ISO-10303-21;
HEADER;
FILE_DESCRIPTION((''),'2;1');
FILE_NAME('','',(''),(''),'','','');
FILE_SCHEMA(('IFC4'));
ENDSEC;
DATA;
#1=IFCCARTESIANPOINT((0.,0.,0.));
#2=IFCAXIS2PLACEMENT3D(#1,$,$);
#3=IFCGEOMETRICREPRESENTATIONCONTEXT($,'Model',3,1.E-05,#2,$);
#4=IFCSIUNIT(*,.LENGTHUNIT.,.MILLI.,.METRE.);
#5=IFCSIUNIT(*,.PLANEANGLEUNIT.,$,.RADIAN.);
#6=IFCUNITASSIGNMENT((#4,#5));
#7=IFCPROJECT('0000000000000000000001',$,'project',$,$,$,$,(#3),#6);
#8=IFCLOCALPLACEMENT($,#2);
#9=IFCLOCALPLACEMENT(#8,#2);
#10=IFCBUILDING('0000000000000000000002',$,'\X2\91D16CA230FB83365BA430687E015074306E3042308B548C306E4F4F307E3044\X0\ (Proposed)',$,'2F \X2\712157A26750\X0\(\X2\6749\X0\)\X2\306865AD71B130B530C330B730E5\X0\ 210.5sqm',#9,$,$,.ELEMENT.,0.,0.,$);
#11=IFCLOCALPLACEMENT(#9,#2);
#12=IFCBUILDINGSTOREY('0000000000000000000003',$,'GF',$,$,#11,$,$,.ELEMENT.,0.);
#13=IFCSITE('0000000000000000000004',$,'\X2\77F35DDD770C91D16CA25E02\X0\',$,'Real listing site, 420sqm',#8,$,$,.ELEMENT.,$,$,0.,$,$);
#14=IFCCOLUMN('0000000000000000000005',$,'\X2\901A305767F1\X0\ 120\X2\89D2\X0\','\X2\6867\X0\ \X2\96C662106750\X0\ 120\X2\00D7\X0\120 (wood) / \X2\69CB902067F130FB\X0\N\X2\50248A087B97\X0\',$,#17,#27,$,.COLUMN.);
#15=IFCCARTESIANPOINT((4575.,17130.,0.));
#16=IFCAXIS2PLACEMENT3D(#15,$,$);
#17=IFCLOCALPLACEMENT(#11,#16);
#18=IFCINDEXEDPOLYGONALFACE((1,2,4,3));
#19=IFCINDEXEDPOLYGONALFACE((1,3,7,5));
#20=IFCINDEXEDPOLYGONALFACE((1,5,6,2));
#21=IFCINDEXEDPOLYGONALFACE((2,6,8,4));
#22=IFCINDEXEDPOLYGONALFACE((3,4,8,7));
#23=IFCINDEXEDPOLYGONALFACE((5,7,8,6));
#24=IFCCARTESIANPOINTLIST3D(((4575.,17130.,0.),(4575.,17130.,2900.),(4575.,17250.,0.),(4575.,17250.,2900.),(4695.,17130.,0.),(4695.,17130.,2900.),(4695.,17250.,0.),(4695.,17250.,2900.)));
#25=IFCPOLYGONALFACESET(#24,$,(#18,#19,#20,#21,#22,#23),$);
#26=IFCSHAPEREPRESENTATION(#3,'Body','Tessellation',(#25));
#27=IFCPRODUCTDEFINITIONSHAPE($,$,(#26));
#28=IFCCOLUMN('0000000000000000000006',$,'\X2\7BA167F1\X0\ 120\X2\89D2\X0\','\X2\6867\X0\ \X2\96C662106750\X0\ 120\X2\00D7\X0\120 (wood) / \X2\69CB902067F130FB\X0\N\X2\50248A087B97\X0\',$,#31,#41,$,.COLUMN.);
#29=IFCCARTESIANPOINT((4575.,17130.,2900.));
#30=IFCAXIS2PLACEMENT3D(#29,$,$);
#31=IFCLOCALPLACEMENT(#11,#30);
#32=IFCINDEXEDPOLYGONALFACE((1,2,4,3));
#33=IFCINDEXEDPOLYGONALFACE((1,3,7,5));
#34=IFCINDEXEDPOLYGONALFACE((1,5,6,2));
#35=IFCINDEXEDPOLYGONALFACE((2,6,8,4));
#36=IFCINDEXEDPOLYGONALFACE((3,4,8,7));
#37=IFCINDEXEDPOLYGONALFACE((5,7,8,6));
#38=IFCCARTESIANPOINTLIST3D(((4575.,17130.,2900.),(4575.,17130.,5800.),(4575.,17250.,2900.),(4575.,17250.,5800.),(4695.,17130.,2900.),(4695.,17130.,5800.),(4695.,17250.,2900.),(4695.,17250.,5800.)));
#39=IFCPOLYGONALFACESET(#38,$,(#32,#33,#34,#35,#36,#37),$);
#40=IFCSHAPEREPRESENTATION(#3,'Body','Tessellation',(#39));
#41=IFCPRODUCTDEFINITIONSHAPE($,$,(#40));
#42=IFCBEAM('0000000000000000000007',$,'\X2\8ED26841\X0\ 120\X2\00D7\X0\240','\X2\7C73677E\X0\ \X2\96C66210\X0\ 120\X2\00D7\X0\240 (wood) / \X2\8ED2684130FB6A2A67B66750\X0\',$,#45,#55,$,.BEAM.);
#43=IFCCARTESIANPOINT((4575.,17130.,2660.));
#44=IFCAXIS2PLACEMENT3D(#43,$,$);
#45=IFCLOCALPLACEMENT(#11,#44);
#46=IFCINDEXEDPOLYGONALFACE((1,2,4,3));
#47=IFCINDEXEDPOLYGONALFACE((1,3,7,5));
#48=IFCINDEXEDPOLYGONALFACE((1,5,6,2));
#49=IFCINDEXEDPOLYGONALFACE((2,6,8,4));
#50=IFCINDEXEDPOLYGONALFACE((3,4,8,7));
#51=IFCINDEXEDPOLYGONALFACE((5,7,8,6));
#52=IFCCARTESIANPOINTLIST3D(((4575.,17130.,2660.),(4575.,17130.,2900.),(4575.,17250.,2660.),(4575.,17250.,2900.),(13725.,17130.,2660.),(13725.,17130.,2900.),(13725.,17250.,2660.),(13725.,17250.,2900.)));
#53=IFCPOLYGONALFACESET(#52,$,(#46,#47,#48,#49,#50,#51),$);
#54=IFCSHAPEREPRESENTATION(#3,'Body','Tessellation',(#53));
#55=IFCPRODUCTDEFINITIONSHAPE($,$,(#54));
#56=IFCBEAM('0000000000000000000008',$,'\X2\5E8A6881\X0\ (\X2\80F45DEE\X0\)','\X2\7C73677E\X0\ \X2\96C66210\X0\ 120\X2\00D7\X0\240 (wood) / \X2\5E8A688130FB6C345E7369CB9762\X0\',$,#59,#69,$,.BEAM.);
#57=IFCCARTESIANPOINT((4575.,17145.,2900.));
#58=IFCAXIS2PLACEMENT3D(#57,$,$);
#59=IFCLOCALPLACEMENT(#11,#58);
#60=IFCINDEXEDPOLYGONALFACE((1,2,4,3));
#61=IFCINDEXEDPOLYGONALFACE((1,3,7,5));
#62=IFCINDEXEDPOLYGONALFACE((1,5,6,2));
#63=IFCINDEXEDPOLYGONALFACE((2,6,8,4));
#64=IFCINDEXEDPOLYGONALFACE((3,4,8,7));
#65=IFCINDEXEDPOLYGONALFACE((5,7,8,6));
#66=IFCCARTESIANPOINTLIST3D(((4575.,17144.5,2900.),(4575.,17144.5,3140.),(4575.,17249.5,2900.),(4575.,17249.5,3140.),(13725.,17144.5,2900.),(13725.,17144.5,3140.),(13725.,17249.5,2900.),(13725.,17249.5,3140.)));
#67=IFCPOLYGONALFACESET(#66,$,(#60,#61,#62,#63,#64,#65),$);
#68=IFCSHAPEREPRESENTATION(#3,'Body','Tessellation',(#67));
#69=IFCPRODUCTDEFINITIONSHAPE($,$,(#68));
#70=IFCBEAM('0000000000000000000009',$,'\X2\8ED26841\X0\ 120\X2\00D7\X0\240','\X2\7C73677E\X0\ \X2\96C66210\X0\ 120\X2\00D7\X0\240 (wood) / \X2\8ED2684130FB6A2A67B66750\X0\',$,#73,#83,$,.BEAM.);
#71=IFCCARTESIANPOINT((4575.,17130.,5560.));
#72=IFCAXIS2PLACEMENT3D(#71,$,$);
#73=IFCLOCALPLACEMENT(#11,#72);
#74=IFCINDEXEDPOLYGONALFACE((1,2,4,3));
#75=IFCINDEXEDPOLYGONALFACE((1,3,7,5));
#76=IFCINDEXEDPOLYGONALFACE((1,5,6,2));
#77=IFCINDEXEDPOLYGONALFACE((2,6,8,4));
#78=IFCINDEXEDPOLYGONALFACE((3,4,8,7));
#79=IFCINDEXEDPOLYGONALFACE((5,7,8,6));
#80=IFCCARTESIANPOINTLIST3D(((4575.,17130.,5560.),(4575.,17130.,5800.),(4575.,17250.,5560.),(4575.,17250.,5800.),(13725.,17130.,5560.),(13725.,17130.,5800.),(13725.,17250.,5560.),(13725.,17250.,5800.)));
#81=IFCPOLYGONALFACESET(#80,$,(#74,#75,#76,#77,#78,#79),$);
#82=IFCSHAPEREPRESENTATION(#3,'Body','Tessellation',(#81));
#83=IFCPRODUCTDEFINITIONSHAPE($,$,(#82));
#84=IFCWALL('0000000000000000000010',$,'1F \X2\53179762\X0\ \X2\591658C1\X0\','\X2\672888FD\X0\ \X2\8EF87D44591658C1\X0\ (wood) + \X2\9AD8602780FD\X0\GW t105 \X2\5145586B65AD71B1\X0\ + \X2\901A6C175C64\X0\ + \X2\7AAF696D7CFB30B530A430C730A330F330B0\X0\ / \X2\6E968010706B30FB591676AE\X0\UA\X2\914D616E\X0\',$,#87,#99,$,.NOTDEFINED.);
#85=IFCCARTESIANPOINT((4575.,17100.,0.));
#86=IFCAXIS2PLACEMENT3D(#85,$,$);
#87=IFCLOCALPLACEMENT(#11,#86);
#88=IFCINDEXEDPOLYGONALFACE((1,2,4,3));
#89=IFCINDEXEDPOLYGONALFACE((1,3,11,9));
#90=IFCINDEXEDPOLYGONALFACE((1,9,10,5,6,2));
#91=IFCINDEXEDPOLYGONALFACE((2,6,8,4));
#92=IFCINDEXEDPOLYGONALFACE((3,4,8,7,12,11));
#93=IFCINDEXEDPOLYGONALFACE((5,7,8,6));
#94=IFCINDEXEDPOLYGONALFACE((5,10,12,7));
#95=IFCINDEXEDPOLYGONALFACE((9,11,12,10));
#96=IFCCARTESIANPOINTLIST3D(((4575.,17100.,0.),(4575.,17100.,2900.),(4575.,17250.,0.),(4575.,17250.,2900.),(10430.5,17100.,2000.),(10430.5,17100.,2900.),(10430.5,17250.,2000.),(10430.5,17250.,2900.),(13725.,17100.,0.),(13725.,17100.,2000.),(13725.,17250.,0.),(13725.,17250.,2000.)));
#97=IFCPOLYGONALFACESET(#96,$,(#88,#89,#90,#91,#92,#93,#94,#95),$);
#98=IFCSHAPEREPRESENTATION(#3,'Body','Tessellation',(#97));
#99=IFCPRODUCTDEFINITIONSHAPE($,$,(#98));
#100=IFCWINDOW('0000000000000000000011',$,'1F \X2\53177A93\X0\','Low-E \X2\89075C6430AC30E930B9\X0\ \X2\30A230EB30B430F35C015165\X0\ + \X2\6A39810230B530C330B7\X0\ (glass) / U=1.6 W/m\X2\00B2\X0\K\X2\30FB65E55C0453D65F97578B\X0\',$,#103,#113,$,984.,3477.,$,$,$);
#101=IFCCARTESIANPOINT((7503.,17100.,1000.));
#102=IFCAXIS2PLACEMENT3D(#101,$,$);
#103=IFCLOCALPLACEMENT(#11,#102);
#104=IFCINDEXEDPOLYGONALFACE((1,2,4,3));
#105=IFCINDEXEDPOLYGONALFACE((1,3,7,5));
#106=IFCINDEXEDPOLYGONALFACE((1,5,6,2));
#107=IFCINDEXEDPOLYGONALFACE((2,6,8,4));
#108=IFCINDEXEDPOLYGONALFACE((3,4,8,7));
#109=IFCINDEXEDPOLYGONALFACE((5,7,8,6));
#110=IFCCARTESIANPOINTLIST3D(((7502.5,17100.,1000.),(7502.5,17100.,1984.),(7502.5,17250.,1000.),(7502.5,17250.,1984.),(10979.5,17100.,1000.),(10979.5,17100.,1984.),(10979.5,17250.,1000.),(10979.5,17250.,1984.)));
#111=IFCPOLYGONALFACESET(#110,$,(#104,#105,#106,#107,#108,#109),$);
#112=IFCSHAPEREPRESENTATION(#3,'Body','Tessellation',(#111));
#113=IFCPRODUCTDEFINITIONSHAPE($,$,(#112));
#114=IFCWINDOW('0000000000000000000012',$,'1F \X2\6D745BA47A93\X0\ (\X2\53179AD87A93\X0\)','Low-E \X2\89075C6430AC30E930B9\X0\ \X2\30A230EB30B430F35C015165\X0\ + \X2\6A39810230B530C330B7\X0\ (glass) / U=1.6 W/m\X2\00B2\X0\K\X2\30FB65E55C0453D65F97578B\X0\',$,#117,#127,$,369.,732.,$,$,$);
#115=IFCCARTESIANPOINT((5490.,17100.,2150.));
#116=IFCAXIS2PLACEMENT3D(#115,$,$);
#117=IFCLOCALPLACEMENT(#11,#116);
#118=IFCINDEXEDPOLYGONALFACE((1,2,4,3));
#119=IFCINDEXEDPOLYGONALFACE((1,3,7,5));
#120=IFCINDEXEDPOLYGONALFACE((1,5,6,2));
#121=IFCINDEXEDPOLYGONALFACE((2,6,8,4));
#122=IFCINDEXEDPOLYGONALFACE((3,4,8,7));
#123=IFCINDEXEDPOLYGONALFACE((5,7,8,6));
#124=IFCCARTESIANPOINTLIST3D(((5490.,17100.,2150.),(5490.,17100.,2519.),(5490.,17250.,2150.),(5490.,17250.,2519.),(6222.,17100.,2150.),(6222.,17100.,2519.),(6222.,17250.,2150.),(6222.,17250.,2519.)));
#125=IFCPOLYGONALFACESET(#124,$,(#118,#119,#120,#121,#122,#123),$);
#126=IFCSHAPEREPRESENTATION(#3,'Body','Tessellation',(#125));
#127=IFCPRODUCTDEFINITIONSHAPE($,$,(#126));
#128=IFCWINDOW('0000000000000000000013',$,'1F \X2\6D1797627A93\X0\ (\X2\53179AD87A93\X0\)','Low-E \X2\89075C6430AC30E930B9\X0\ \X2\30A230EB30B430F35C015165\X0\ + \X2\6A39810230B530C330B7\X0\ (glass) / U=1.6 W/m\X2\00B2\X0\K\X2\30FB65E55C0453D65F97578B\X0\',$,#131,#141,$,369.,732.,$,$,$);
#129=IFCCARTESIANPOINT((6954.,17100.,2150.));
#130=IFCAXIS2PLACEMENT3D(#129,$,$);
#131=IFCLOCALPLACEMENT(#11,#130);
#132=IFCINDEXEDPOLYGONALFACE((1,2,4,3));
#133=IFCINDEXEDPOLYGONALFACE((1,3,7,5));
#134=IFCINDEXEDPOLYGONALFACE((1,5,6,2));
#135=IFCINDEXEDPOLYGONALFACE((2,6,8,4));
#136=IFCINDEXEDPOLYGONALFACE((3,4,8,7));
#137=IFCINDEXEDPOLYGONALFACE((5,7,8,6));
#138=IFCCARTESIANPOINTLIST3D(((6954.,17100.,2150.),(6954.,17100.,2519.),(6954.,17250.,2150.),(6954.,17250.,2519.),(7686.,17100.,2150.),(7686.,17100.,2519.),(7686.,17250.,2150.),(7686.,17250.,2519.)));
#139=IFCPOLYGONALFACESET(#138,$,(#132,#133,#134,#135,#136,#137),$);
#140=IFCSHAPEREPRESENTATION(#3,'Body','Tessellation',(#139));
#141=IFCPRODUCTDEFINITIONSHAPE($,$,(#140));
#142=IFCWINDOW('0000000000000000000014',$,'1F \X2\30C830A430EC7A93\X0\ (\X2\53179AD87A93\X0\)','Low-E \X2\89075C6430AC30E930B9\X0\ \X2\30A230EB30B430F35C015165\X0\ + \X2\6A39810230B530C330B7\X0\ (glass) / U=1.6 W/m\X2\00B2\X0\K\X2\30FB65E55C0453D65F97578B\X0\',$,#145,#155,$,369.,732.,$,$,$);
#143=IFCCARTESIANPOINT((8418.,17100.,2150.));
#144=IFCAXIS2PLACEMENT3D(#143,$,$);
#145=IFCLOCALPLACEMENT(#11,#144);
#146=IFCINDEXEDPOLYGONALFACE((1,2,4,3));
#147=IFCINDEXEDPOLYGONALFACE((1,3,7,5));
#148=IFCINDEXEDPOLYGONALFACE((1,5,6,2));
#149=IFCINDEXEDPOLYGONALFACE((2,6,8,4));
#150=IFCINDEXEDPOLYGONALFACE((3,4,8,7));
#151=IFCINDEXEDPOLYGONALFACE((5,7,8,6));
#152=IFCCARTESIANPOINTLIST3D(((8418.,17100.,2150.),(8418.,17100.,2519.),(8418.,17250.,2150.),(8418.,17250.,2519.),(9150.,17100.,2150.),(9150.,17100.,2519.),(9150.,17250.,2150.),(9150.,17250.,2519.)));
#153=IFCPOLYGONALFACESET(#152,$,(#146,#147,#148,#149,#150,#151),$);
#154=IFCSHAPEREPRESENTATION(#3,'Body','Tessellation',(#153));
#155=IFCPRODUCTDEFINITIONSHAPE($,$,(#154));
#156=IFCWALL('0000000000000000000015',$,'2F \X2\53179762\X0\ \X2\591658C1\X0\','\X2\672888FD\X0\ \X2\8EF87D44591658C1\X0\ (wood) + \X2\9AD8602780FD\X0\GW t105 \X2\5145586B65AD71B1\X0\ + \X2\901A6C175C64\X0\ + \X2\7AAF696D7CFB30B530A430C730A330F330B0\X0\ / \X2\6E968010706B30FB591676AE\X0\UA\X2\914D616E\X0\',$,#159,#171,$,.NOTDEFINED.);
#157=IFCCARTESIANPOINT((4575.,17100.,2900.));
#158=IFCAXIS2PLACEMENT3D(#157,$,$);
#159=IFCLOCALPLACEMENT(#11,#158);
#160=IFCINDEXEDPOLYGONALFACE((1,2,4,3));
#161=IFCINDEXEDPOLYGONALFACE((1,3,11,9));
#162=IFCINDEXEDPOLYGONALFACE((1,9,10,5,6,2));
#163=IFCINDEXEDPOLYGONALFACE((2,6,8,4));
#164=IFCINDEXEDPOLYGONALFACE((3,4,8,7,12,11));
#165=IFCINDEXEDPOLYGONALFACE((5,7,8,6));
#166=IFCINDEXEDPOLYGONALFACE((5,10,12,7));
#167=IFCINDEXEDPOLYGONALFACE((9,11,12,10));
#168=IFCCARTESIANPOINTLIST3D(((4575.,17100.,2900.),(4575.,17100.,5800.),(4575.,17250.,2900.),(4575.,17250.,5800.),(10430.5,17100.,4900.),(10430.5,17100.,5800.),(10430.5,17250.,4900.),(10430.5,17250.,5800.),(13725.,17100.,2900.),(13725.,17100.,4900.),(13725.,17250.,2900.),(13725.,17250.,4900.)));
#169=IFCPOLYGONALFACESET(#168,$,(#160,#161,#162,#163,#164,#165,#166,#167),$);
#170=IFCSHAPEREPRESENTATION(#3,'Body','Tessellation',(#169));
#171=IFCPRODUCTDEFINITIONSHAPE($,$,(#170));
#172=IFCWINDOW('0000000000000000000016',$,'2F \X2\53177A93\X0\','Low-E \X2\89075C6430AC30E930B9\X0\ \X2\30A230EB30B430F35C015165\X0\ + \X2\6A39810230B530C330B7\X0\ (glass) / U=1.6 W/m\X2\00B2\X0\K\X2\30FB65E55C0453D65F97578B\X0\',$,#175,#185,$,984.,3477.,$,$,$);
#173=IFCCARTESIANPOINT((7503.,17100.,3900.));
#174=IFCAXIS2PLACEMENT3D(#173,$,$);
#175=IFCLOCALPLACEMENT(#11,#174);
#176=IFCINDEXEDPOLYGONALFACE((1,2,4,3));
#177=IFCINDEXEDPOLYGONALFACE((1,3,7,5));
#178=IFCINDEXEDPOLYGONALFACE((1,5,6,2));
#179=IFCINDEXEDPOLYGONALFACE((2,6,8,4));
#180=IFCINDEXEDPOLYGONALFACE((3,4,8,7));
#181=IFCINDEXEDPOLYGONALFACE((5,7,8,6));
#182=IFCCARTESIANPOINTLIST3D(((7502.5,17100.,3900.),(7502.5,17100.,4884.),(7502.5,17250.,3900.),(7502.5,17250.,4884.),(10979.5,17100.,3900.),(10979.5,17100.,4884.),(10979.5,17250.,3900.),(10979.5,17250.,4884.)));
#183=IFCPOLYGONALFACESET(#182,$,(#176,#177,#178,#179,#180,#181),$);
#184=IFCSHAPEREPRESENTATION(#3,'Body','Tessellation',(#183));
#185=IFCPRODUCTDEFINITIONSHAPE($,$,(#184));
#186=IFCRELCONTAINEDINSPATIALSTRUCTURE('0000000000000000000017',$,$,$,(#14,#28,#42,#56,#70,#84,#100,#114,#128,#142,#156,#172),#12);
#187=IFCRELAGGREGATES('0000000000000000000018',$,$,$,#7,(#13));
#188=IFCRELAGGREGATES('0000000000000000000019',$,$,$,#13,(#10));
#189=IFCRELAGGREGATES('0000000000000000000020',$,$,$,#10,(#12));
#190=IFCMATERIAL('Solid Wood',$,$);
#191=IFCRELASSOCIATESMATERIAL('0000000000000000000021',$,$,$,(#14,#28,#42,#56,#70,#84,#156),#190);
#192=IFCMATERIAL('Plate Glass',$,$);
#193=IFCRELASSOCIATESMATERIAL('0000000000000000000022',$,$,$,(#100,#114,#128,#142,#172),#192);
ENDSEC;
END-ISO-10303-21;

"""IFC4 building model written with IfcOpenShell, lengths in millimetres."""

from ifc_helpers import new_model, si_unit, frame, frame_2d, origin, place, context, project, spatial, rectangle, extrude, material, element, fill, save


model = new_model("IFC4")

# Units and contexts
model_context = context("Model", 3, precision=1e-05, world=origin())
ifc_project = project(units=[si_unit("LENGTHUNIT", "METRE", prefix="MILLI"), si_unit("PLANEANGLEUNIT", "RADIAN")], contexts=[model_context])

# Site, building, storey
site_placement = place(None, origin())
site = spatial("IfcSite", under=ifc_project, at=site_placement, Name="石川県金沢市", ObjectType="Real listing site, 420sqm", CompositionType="ELEMENT", RefElevation=0.0)
building_placement = place(site_placement, origin())
building = spatial("IfcBuilding", under=site, at=building_placement, Name="金沢・茶室と縁側のある和の住まい (Proposed)", ObjectType="2F 無垢材(杉)と断熱サッシュ 210.5sqm", CompositionType="ELEMENT", ElevationOfRefHeight=0.0, ElevationOfTerrain=0.0)
storey_placement = place(building_placement, origin())
storey = spatial("IfcBuildingStorey", under=building, at=storey_placement, Name="GF", CompositionType="ELEMENT", Elevation=0.0)

# Columns
ifc_material_1 = material(Name="Solid Wood")
column_1_placement = place(storey_placement, frame((4575.0, 17130.0, 0.0)))
element("IfcColumn", 1, at=column_1_placement, inside=storey, material=ifc_material_1, Name="通し柱 120角", Description="桧 集成材 120×120 (wood) / 構造柱・N値計算", PredefinedType="COLUMN", context=model_context, shape_type="SweptSolid", body=[
    extrude(rectangle(XDim=120.0, YDim=120.0, at=frame_2d((60.0, 60.0))), frame((4575.0, 17130.0, 0.0)), (0.0, 0.0, 1.0), 2900.0),
])
column_2_placement = place(storey_placement, frame((4575.0, 17130.0, 2900.0)))
element("IfcColumn", 2, at=column_2_placement, inside=storey, material=ifc_material_1, Name="管柱 120角", Description="桧 集成材 120×120 (wood) / 構造柱・N値計算", PredefinedType="COLUMN", context=model_context, shape_type="SweptSolid", body=[
    extrude(rectangle(XDim=120.0, YDim=120.0, at=frame_2d((60.0, 60.0))), frame((4575.0, 17130.0, 2900.0)), (0.0, 0.0, 1.0), 2900.0),
])

# Beams
beam_1_placement = place(storey_placement, frame((4575.0, 17130.0, 2660.0)))
element("IfcBeam", 3, at=beam_1_placement, inside=storey, material=ifc_material_1, Name="軒桁 120×240", Description="米松 集成 120×240 (wood) / 軒桁・横架材", PredefinedType="BEAM", context=model_context, shape_type="SweptSolid", body=[
    extrude(rectangle(XDim=9150.0, YDim=120.0, at=frame_2d((4575.0, 60.0))), frame((4575.0, 17130.0, 2660.0)), (0.0, 0.0, 1.0), 240.0),
])
beam_2_placement = place(storey_placement, frame((4575.0, 17145.0, 2900.0)))
element("IfcBeam", 4, at=beam_2_placement, inside=storey, material=ifc_material_1, Name="床梁 (胴差)", Description="米松 集成 120×240 (wood) / 床梁・水平構面", PredefinedType="BEAM", context=model_context, shape_type="SweptSolid", body=[
    extrude(rectangle(XDim=9150.0, YDim=105.0, at=frame_2d((4575.0, 52.0))), frame((4575.0, 17145.0, 2900.0)), (0.0, 0.0, 1.0), 240.0),
])
beam_3_placement = place(storey_placement, frame((4575.0, 17130.0, 5560.0)))
element("IfcBeam", 5, at=beam_3_placement, inside=storey, material=ifc_material_1, Name="軒桁 120×240", Description="米松 集成 120×240 (wood) / 軒桁・横架材", PredefinedType="BEAM", context=model_context, shape_type="SweptSolid", body=[
    extrude(rectangle(XDim=9150.0, YDim=120.0, at=frame_2d((4575.0, 60.0))), frame((4575.0, 17130.0, 5560.0)), (0.0, 0.0, 1.0), 240.0),
])

# Wall, openings, windows
wall_1_placement = place(storey_placement, frame((4575.0, 17100.0, 0.0)))
wall_1 = element("IfcWall", 6, at=wall_1_placement, inside=storey, material=ifc_material_1, Name="1F 北面 外壁", Description="木製 軸組外壁 (wood) + 高性能GW t105 充填断熱 + 通気層 + 窯業系サイディング / 準耐火・外皮UA配慮", PredefinedType="NOTDEFINED", context=model_context, shape_type="SweptSolid", body=[
    extrude(rectangle(XDim=9150.0, YDim=150.0, at=frame_2d((4575.0, 75.0))), frame((4575.0, 17100.0, 0.0)), (0.0, 0.0, 1.0), 2900.0),
])
opening_1_placement = place(storey_placement, frame((7503.0, 17100.0, 1000.0)))
opening_1 = element("IfcOpeningElement", 7, at=opening_1_placement, cuts=wall_1, PredefinedType="NOTDEFINED", context=model_context, shape_type="SweptSolid", body=[
    extrude(rectangle(XDim=3477.0, YDim=150.0, at=frame_2d((1738.0, 75.0))), frame((7503.0, 17100.0, 1000.0)), (0.0, 0.0, 1.0), 984.0),
])
opening_2_placement = place(storey_placement, frame((5490.0, 17100.0, 2150.0)))
opening_2 = element("IfcOpeningElement", 8, at=opening_2_placement, cuts=wall_1, PredefinedType="NOTDEFINED", context=model_context, shape_type="SweptSolid", body=[
    extrude(rectangle(XDim=732.0, YDim=150.0, at=frame_2d((366.0, 75.0))), frame((5490.0, 17100.0, 2150.0)), (0.0, 0.0, 1.0), 369.0),
])
opening_3_placement = place(storey_placement, frame((6954.0, 17100.0, 2150.0)))
opening_3 = element("IfcOpeningElement", 9, at=opening_3_placement, cuts=wall_1, PredefinedType="NOTDEFINED", context=model_context, shape_type="SweptSolid", body=[
    extrude(rectangle(XDim=732.0, YDim=150.0, at=frame_2d((366.0, 75.0))), frame((6954.0, 17100.0, 2150.0)), (0.0, 0.0, 1.0), 369.0),
])
opening_4_placement = place(storey_placement, frame((8418.0, 17100.0, 2150.0)))
opening_4 = element("IfcOpeningElement", 10, at=opening_4_placement, cuts=wall_1, PredefinedType="NOTDEFINED", context=model_context, shape_type="SweptSolid", body=[
    extrude(rectangle(XDim=732.0, YDim=150.0, at=frame_2d((366.0, 75.0))), frame((8418.0, 17100.0, 2150.0)), (0.0, 0.0, 1.0), 369.0),
])
ifc_material_2 = material(Name="Plate Glass")
window_1_placement = place(storey_placement, frame((7503.0, 17100.0, 1000.0)))
window_1 = element("IfcWindow", 11, at=window_1_placement, inside=storey, material=ifc_material_2, Name="1F 北窓", Description="Low-E 複層ガラス アルゴン封入 + 樹脂サッシ (glass) / U=1.6 W/m²K・日射取得型", OverallHeight=984.0, OverallWidth=3477.0, context=model_context, shape_type="SweptSolid", body=[
    extrude(rectangle(XDim=3477.0, YDim=150.0, at=frame_2d((1738.0, 75.0))), frame((7503.0, 17100.0, 1000.0)), (0.0, 0.0, 1.0), 984.0),
])
fill(opening_1, window_1)
window_2_placement = place(storey_placement, frame((5490.0, 17100.0, 2150.0)))
window_2 = element("IfcWindow", 12, at=window_2_placement, inside=storey, material=ifc_material_2, Name="1F 浴室窓 (北高窓)", Description="Low-E 複層ガラス アルゴン封入 + 樹脂サッシ (glass) / U=1.6 W/m²K・日射取得型", OverallHeight=369.0, OverallWidth=732.0, context=model_context, shape_type="SweptSolid", body=[
    extrude(rectangle(XDim=732.0, YDim=150.0, at=frame_2d((366.0, 75.0))), frame((5490.0, 17100.0, 2150.0)), (0.0, 0.0, 1.0), 369.0),
])
fill(opening_2, window_2)
window_3_placement = place(storey_placement, frame((6954.0, 17100.0, 2150.0)))
window_3 = element("IfcWindow", 13, at=window_3_placement, inside=storey, material=ifc_material_2, Name="1F 洗面窓 (北高窓)", Description="Low-E 複層ガラス アルゴン封入 + 樹脂サッシ (glass) / U=1.6 W/m²K・日射取得型", OverallHeight=369.0, OverallWidth=732.0, context=model_context, shape_type="SweptSolid", body=[
    extrude(rectangle(XDim=732.0, YDim=150.0, at=frame_2d((366.0, 75.0))), frame((6954.0, 17100.0, 2150.0)), (0.0, 0.0, 1.0), 369.0),
])
fill(opening_3, window_3)
window_4_placement = place(storey_placement, frame((8418.0, 17100.0, 2150.0)))
window_4 = element("IfcWindow", 14, at=window_4_placement, inside=storey, material=ifc_material_2, Name="1F トイレ窓 (北高窓)", Description="Low-E 複層ガラス アルゴン封入 + 樹脂サッシ (glass) / U=1.6 W/m²K・日射取得型", OverallHeight=369.0, OverallWidth=732.0, context=model_context, shape_type="SweptSolid", body=[
    extrude(rectangle(XDim=732.0, YDim=150.0, at=frame_2d((366.0, 75.0))), frame((8418.0, 17100.0, 2150.0)), (0.0, 0.0, 1.0), 369.0),
])
fill(opening_4, window_4)

# Wall, opening, window
wall_2_placement = place(storey_placement, frame((4575.0, 17100.0, 2900.0)))
wall_2 = element("IfcWall", 15, at=wall_2_placement, inside=storey, material=ifc_material_1, Name="2F 北面 外壁", Description="木製 軸組外壁 (wood) + 高性能GW t105 充填断熱 + 通気層 + 窯業系サイディング / 準耐火・外皮UA配慮", PredefinedType="NOTDEFINED", context=model_context, shape_type="SweptSolid", body=[
    extrude(rectangle(XDim=9150.0, YDim=150.0, at=frame_2d((4575.0, 75.0))), frame((4575.0, 17100.0, 2900.0)), (0.0, 0.0, 1.0), 2900.0),
])
opening_5_placement = place(storey_placement, frame((7503.0, 17100.0, 3900.0)))
opening_5 = element("IfcOpeningElement", 16, at=opening_5_placement, cuts=wall_2, PredefinedType="NOTDEFINED", context=model_context, shape_type="SweptSolid", body=[
    extrude(rectangle(XDim=3477.0, YDim=150.0, at=frame_2d((1738.0, 75.0))), frame((7503.0, 17100.0, 3900.0)), (0.0, 0.0, 1.0), 984.0),
])
window_5_placement = place(storey_placement, frame((7503.0, 17100.0, 3900.0)))
window_5 = element("IfcWindow", 17, at=window_5_placement, inside=storey, material=ifc_material_2, Name="2F 北窓", Description="Low-E 複層ガラス アルゴン封入 + 樹脂サッシ (glass) / U=1.6 W/m²K・日射取得型", OverallHeight=984.0, OverallWidth=3477.0, context=model_context, shape_type="SweptSolid", body=[
    extrude(rectangle(XDim=3477.0, YDim=150.0, at=frame_2d((1738.0, 75.0))), frame((7503.0, 17100.0, 3900.0)), (0.0, 0.0, 1.0), 984.0),
])
fill(opening_5, window_5)

save(model, "model.ifc")
